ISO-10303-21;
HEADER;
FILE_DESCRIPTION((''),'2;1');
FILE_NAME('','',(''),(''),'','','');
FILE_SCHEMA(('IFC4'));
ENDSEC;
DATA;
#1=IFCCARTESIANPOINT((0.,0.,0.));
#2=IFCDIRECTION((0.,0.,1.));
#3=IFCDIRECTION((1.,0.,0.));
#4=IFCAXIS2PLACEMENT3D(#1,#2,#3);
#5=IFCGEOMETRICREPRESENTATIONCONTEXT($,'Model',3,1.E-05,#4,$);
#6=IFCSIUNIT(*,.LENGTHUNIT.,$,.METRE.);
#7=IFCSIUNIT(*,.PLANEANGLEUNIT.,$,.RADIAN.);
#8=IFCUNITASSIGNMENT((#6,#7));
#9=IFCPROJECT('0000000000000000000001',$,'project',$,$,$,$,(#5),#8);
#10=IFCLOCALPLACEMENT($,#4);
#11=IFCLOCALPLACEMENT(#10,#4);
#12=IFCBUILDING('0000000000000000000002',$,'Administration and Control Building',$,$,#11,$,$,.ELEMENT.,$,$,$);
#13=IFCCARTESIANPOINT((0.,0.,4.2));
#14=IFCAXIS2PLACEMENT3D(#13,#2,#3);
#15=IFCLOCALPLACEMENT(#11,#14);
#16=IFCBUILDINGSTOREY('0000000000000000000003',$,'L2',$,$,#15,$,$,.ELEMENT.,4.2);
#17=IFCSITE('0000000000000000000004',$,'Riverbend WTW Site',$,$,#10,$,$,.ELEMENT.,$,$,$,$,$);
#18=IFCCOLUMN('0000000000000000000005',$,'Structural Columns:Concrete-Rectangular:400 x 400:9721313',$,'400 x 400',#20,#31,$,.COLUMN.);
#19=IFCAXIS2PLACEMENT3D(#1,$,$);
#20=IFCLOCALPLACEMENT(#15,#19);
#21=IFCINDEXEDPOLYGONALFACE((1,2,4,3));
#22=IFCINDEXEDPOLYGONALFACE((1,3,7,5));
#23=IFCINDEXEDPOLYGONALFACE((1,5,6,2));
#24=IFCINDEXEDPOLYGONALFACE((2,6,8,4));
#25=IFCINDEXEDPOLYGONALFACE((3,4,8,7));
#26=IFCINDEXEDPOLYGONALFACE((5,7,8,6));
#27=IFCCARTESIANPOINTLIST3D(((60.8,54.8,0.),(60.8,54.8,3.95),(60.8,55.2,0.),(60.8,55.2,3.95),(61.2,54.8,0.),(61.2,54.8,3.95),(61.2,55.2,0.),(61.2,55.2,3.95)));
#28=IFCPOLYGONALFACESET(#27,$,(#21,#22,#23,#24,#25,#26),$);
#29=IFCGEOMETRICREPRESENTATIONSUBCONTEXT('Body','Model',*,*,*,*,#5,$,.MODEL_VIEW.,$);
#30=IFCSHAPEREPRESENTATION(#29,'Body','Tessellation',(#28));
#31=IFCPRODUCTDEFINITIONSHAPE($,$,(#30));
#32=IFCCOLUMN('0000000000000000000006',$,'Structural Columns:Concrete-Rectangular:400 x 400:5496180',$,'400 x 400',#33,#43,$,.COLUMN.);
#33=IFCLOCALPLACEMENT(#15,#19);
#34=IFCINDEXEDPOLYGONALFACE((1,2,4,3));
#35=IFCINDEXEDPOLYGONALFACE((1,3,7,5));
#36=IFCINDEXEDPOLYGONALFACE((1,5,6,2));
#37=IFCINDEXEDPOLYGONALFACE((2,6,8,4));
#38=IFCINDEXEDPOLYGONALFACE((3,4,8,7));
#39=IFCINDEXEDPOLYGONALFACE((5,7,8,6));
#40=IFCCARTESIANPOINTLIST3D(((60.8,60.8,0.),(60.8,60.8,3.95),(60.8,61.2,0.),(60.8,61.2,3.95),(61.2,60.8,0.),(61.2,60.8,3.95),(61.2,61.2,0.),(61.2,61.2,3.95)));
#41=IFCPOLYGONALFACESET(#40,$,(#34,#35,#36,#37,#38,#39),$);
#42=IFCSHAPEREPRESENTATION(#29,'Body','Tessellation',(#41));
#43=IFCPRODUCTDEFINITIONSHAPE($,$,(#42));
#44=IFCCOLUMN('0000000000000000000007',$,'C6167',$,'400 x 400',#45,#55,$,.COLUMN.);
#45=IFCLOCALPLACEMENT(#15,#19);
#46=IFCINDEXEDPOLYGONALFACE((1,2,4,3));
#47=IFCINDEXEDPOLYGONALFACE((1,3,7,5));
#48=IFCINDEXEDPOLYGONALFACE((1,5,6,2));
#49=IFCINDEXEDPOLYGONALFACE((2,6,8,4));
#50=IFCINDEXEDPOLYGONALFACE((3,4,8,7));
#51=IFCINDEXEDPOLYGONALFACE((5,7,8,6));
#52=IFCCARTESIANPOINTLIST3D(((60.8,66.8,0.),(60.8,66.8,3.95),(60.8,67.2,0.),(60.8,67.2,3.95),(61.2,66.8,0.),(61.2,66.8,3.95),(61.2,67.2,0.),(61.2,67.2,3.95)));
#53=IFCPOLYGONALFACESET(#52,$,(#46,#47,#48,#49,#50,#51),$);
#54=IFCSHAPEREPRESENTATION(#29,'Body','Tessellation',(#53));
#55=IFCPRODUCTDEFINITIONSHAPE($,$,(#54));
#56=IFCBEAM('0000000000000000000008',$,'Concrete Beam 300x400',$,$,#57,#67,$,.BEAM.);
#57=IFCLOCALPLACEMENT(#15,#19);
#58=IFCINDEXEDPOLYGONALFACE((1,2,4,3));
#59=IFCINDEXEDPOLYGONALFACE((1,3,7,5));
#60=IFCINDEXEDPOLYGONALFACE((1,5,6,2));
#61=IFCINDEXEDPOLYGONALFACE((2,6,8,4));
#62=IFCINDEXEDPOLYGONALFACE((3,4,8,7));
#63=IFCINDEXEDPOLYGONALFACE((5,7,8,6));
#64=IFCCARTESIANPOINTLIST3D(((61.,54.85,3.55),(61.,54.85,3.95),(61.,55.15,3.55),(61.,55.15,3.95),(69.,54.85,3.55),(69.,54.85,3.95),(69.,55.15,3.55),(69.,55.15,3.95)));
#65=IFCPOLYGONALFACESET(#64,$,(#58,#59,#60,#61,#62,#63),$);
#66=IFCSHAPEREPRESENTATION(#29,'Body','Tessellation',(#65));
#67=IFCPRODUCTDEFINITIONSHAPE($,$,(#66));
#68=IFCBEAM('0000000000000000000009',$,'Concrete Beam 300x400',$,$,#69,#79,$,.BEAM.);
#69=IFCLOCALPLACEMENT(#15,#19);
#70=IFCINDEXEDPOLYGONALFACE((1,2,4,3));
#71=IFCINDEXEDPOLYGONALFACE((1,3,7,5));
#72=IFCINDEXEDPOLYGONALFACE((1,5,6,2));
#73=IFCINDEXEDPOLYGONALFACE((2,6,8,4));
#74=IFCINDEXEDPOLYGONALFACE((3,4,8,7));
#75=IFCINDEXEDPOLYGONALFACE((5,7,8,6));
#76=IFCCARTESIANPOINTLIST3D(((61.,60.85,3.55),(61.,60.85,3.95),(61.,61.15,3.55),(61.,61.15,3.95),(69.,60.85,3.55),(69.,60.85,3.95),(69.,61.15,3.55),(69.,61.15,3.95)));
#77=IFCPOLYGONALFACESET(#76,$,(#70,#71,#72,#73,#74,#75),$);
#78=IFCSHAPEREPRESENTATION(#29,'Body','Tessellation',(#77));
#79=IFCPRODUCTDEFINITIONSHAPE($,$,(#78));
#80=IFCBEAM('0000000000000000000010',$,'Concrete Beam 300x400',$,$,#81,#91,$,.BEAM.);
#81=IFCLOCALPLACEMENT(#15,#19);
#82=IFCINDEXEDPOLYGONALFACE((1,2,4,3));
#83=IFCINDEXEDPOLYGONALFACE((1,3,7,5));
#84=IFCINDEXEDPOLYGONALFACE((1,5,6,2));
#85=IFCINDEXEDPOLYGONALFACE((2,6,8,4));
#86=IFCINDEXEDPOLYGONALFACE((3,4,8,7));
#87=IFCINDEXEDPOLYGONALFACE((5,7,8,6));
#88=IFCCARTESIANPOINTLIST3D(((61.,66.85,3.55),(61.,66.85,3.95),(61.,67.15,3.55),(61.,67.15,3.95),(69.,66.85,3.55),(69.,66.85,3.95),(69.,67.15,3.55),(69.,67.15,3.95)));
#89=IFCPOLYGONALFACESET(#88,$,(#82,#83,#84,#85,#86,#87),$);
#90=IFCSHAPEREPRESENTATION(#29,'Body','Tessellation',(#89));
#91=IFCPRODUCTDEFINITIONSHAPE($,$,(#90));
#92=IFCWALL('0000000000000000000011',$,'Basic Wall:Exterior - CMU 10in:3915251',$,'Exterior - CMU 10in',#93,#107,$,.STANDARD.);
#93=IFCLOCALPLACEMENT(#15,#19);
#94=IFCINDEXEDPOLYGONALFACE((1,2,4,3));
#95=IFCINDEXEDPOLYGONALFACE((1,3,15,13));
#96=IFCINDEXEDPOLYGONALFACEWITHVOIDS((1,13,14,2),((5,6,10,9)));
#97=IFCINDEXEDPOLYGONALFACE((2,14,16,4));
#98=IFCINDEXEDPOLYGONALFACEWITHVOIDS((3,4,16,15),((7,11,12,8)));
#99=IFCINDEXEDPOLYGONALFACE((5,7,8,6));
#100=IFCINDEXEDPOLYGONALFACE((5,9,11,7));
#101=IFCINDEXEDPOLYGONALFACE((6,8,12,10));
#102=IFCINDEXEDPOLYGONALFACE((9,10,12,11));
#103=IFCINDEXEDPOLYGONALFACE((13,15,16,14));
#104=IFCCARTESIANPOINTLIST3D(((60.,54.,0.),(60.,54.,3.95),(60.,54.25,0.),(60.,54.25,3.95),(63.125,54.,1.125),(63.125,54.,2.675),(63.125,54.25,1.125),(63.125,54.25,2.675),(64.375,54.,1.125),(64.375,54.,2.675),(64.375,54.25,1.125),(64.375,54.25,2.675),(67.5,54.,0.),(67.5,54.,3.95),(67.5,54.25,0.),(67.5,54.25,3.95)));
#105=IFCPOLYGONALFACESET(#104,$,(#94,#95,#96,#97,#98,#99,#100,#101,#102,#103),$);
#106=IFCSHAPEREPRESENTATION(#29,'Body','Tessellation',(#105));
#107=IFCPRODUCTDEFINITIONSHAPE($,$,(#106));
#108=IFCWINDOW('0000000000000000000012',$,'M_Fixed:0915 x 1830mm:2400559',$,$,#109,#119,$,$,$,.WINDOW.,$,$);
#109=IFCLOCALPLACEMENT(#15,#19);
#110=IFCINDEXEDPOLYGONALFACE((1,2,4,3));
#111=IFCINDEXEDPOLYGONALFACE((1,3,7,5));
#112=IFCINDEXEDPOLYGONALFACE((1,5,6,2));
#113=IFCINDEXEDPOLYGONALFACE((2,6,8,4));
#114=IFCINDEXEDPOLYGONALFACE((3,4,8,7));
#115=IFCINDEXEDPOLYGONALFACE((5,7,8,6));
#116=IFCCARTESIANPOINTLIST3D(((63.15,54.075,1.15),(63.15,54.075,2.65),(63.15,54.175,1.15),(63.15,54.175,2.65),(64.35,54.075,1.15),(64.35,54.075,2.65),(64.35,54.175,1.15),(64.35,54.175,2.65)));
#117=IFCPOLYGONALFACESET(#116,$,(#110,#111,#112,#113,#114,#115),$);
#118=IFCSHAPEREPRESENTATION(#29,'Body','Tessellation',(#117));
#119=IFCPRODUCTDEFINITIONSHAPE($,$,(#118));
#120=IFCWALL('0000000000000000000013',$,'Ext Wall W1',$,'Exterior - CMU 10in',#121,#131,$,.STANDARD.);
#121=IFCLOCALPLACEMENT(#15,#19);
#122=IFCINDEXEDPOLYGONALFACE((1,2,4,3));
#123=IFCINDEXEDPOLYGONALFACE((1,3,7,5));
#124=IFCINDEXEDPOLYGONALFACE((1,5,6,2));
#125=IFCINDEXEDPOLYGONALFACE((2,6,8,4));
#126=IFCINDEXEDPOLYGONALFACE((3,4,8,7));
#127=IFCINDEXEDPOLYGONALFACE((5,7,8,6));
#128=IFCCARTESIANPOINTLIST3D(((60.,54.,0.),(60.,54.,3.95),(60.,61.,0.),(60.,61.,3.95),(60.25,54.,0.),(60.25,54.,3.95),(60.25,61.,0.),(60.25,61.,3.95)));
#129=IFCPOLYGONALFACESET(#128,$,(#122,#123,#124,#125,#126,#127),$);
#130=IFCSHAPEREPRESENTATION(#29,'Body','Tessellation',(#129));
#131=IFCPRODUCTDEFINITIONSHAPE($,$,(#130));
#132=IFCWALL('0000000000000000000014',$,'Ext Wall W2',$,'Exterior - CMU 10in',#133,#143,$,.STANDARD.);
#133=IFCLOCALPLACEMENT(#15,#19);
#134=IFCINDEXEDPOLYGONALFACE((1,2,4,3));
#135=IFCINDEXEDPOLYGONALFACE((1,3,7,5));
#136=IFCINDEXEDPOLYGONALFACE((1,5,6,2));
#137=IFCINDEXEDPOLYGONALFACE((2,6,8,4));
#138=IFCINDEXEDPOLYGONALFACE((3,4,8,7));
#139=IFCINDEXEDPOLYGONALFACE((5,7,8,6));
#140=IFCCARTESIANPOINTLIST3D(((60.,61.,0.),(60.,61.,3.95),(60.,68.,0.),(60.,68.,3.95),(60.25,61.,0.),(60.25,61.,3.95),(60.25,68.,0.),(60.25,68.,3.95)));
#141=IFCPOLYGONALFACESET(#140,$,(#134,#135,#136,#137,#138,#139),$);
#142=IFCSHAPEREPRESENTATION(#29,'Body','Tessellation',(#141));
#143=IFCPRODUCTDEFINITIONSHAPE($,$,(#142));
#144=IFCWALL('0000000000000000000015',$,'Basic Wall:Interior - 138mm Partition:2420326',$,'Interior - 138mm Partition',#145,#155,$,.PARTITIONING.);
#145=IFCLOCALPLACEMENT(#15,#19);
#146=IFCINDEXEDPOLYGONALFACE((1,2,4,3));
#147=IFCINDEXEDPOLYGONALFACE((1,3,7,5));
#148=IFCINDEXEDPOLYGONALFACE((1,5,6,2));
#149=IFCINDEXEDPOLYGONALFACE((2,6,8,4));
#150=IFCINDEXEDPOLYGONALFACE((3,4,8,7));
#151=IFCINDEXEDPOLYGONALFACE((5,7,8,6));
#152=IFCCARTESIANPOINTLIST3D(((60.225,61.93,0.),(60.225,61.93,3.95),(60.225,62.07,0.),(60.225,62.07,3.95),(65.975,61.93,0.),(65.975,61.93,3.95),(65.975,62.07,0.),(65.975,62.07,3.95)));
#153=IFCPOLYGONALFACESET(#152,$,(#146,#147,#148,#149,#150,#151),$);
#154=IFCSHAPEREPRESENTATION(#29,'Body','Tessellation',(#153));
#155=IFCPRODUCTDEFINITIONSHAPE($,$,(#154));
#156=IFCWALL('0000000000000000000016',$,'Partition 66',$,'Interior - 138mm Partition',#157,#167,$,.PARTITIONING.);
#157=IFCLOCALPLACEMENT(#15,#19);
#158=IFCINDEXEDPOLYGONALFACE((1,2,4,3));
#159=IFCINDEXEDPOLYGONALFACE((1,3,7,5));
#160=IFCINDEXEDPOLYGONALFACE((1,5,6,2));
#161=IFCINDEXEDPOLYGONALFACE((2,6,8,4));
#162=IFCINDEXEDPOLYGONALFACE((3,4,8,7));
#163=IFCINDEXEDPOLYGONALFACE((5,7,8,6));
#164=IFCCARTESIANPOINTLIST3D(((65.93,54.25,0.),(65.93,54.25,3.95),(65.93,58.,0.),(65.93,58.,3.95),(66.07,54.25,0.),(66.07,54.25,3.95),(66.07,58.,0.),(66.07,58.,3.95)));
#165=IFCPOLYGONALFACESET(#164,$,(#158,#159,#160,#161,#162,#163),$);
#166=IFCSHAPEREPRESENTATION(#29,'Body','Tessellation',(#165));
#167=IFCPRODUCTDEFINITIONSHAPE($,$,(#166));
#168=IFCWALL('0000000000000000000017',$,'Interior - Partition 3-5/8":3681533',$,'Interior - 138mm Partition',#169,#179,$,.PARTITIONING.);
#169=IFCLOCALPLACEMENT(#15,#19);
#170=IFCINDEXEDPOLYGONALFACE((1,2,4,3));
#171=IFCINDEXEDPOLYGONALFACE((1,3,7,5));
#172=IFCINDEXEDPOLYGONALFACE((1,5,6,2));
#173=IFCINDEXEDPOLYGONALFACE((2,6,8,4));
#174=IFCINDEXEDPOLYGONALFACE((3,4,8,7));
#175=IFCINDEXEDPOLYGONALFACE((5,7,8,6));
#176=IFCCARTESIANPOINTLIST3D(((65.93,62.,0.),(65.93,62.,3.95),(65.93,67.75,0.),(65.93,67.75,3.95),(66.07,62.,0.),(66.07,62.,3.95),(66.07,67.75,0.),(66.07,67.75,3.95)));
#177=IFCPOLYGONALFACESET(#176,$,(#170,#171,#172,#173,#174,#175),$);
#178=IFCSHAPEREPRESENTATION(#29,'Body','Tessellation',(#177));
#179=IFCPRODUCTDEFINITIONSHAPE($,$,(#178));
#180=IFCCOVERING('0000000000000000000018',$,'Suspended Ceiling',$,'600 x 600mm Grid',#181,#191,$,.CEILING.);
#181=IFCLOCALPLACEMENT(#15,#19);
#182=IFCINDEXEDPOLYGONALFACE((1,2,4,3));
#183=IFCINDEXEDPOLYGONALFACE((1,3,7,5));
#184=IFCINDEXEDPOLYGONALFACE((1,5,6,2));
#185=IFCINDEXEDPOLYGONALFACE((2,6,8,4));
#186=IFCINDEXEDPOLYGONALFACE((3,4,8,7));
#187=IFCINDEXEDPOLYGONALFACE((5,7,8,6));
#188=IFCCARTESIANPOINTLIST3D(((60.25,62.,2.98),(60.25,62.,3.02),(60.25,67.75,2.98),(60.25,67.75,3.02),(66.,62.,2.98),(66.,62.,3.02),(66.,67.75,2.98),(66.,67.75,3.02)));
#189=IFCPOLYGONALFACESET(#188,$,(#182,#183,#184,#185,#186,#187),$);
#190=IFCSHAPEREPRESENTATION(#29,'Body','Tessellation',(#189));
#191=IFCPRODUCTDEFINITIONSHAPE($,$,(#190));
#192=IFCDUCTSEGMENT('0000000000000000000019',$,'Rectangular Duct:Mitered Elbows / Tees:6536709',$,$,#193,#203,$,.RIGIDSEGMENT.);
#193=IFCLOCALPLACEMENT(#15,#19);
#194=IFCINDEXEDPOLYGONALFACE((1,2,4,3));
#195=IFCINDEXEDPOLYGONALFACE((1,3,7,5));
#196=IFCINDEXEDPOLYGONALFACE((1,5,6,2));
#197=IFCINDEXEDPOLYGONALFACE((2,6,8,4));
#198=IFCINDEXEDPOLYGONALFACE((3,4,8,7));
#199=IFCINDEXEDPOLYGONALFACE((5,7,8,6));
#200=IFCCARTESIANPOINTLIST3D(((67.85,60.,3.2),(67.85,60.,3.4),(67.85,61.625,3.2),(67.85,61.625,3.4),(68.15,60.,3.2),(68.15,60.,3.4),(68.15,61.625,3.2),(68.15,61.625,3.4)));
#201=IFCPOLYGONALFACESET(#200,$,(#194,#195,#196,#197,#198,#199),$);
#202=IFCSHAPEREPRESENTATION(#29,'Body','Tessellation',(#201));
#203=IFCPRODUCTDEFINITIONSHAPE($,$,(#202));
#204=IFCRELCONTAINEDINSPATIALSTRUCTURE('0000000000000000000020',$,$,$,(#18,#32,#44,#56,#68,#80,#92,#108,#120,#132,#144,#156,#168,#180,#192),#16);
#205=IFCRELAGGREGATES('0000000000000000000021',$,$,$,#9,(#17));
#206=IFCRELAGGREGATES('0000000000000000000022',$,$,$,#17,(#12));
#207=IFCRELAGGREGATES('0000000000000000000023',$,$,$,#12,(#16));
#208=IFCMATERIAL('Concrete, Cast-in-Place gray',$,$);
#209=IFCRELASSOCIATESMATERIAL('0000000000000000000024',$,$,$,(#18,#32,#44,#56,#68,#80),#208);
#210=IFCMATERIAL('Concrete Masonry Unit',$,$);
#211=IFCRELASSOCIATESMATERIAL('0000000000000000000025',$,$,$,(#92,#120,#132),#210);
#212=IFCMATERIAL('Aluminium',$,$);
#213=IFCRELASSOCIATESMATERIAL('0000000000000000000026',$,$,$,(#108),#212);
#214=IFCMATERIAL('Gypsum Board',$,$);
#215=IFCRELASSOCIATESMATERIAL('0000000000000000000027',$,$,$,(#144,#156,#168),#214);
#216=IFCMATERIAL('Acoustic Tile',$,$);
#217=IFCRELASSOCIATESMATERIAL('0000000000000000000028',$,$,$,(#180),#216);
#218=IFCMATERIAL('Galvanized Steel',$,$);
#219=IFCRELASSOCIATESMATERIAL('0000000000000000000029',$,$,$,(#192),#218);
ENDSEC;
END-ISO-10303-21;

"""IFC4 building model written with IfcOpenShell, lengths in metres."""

from ifc_helpers import new_model, si_unit, frame, origin_with_axes, origin_2d, place, context, subcontext, project, spatial, rectangle, extrude, material, element, fill, save


model = new_model("IFC4")

# Units and contexts
model_context = context("Model", 3, precision=1e-05, world=origin_with_axes())
body_context = subcontext(model_context, "Body", "Model", "MODEL_VIEW")
ifc_project = project(units=[si_unit("LENGTHUNIT", "METRE"), si_unit("PLANEANGLEUNIT", "RADIAN")], contexts=[model_context])

# Site, building, storey
site_placement = place(None, origin_with_axes())
site = spatial("IfcSite", under=ifc_project, at=site_placement, Name="Riverbend WTW Site", CompositionType="ELEMENT")
building_placement = place(site_placement, origin_with_axes())
building = spatial("IfcBuilding", under=site, at=building_placement, Name="Administration and Control Building", CompositionType="ELEMENT")
storey_placement = place(building_placement, frame((0.0, 0.0, 4.2), z_axis=(0.0, 0.0, 1.0), x_axis=(1.0, 0.0, 0.0)))
storey = spatial("IfcBuildingStorey", under=building, at=storey_placement, Name="L2", CompositionType="ELEMENT", Elevation=4.2)

# Columns
ifc_material_1 = material(Name="Concrete, Cast-in-Place gray")
for number, where, z_axis, x_axis, name in (
    (1, (61.0, 55.0, 6.175), (0.0, 0.0, 1.0), (1.0, 0.0, 0.0), "Structural Columns:Concrete-Rectangular:400 x 400:9721313"),
    (2, (61.0, 61.0, 6.175), (0.0, 0.0, 1.0), (1.0, 0.0, 0.0), "Structural Columns:Concrete-Rectangular:400 x 400:5496180"),
    (3, (61.0, 67.0, 6.175), (0.0, 0.0, 1.0), (1.0, 0.0, 0.0), "C6167"),
):
    element("IfcColumn", number, at=place(None, frame(where, z_axis=z_axis, x_axis=x_axis)), inside=storey, material=ifc_material_1, Name=name, ObjectType="400 x 400", PredefinedType="COLUMN", context=body_context, shape_type="SweptSolid", body=[
        extrude(rectangle(XDim=0.4, YDim=0.4, at=origin_2d()), frame((0.0, 0.0, -1.975), z_axis=(0.0, 0.0, 1.0), x_axis=(1.0, 0.0, 0.0)), (0.0, 0.0, 1.0), 3.95),
    ])

# Beams
for number, where, z_axis, x_axis, name in (
    (4, (65.0, 55.0, 7.95), (0.0, 0.0, 1.0), (1.0, 0.0, 0.0), "Concrete Beam 300x400"),
    (5, (65.0, 61.0, 7.95), (0.0, 0.0, 1.0), (1.0, 0.0, 0.0), "Concrete Beam 300x400"),
    (6, (65.0, 67.0, 7.95), (0.0, 0.0, 1.0), (1.0, 0.0, 0.0), "Concrete Beam 300x400"),
):
    element("IfcBeam", number, at=place(None, frame(where, z_axis=z_axis, x_axis=x_axis)), inside=storey, material=ifc_material_1, Name=name, PredefinedType="BEAM", context=body_context, shape_type="SweptSolid", body=[
        extrude(rectangle(XDim=8.0, YDim=0.3, at=origin_2d()), frame((0.0, 0.0, -0.2), z_axis=(0.0, 0.0, 1.0), x_axis=(1.0, 0.0, 0.0)), (0.0, 0.0, 1.0), 0.4),
    ])

# Wall, opening, window
ifc_material_2 = material(Name="Concrete Masonry Unit")
wall_1_placement = place(None, frame((63.75, 54.125, 6.175), z_axis=(0.0, 0.0, 1.0), x_axis=(1.0, 0.0, 0.0)))
wall_1 = element("IfcWall", 7, at=wall_1_placement, inside=storey, material=ifc_material_2, Name="Basic Wall:Exterior - CMU 10in:3915251", ObjectType="Exterior - CMU 10in", PredefinedType="STANDARD", context=body_context, shape_type="SweptSolid", body=[
    extrude(rectangle(XDim=7.5, YDim=0.25, at=origin_2d()), frame((0.0, 0.0, -1.975), z_axis=(0.0, 0.0, 1.0), x_axis=(1.0, 0.0, 0.0)), (0.0, 0.0, 1.0), 3.95),
])
opening_placement = place(None, frame((63.75, 54.125, 6.1), z_axis=(0.0, 0.0, 1.0), x_axis=(1.0, 0.0, 0.0)))
opening = element("IfcOpeningElement", 8, at=opening_placement, inside=storey, cuts=wall_1, context=body_context, shape_type="SweptSolid", body=[
    extrude(rectangle(XDim=1.25, YDim=0.4, at=origin_2d()), frame((0.0, 0.0, -0.775), z_axis=(0.0, 0.0, 1.0), x_axis=(1.0, 0.0, 0.0)), (0.0, 0.0, 1.0), 1.55),
])
ifc_material_3 = material(Name="Aluminium")
window_placement = place(None, frame((63.75, 54.125, 6.1), z_axis=(0.0, 0.0, 1.0), x_axis=(1.0, 0.0, 0.0)))
window = element("IfcWindow", 9, at=window_placement, inside=storey, material=ifc_material_3, Name="M_Fixed:0915 x 1830mm:2400559", PredefinedType="WINDOW", context=body_context, shape_type="SweptSolid", body=[
    extrude(rectangle(XDim=1.2, YDim=0.1, at=origin_2d()), frame((0.0, 0.0, -0.75), z_axis=(0.0, 0.0, 1.0), x_axis=(1.0, 0.0, 0.0)), (0.0, 0.0, 1.0), 1.5),
])
fill(opening, window)

# Walls
for number, where, z_axis, x_axis, name in (
    (10, (60.125, 57.5, 6.175), (0.0, 0.0, 1.0), (1.0, 0.0, 0.0), "Ext Wall W1"),
    (11, (60.125, 64.5, 6.175), (0.0, 0.0, 1.0), (1.0, 0.0, 0.0), "Ext Wall W2"),
):
    element("IfcWall", number, at=place(None, frame(where, z_axis=z_axis, x_axis=x_axis)), inside=storey, material=ifc_material_2, Name=name, ObjectType="Exterior - CMU 10in", PredefinedType="STANDARD", context=body_context, shape_type="SweptSolid", body=[
        extrude(rectangle(XDim=0.25, YDim=7.0, at=origin_2d()), frame((0.0, 0.0, -1.975), z_axis=(0.0, 0.0, 1.0), x_axis=(1.0, 0.0, 0.0)), (0.0, 0.0, 1.0), 3.95),
    ])
ifc_material_4 = material(Name="Gypsum Board")
wall_2_placement = place(None, frame((63.1, 62.0, 6.175), z_axis=(0.0, 0.0, 1.0), x_axis=(1.0, 0.0, 0.0)))
element("IfcWall", 12, at=wall_2_placement, inside=storey, material=ifc_material_4, Name="Basic Wall:Interior - 138mm Partition:2420326", ObjectType="Interior - 138mm Partition", PredefinedType="PARTITIONING", context=body_context, shape_type="SweptSolid", body=[
    extrude(rectangle(XDim=5.75, YDim=0.14, at=origin_2d()), frame((0.0, 0.0, -1.975), z_axis=(0.0, 0.0, 1.0), x_axis=(1.0, 0.0, 0.0)), (0.0, 0.0, 1.0), 3.95),
])
wall_3_placement = place(None, frame((66.0, 56.125, 6.175), z_axis=(0.0, 0.0, 1.0), x_axis=(1.0, 0.0, 0.0)))
element("IfcWall", 13, at=wall_3_placement, inside=storey, material=ifc_material_4, Name="Partition 66", ObjectType="Interior - 138mm Partition", PredefinedType="PARTITIONING", context=body_context, shape_type="SweptSolid", body=[
    extrude(rectangle(XDim=0.14, YDim=3.75, at=origin_2d()), frame((0.0, 0.0, -1.975), z_axis=(0.0, 0.0, 1.0), x_axis=(1.0, 0.0, 0.0)), (0.0, 0.0, 1.0), 3.95),
])
wall_4_placement = place(None, frame((66.0, 64.875, 6.175), z_axis=(0.0, 0.0, 1.0), x_axis=(1.0, 0.0, 0.0)))
element("IfcWall", 14, at=wall_4_placement, inside=storey, material=ifc_material_4, Name="Interior - Partition 3-5/8\":3681533", ObjectType="Interior - 138mm Partition", PredefinedType="PARTITIONING", context=body_context, shape_type="SweptSolid", body=[
    extrude(rectangle(XDim=0.14, YDim=5.75, at=origin_2d()), frame((0.0, 0.0, -1.975), z_axis=(0.0, 0.0, 1.0), x_axis=(1.0, 0.0, 0.0)), (0.0, 0.0, 1.0), 3.95),
])

# Covering
ifc_material_5 = material(Name="Acoustic Tile")
covering_placement = place(None, frame((63.125, 64.875, 7.2), z_axis=(0.0, 0.0, 1.0), x_axis=(1.0, 0.0, 0.0)))
element("IfcCovering", 15, at=covering_placement, inside=storey, material=ifc_material_5, Name="Suspended Ceiling", ObjectType="600 x 600mm Grid", PredefinedType="CEILING", context=body_context, shape_type="SweptSolid", body=[
    extrude(rectangle(XDim=5.75, YDim=5.75, at=origin_2d()), frame((0.0, 0.0, -0.02), z_axis=(0.0, 0.0, 1.0), x_axis=(1.0, 0.0, 0.0)), (0.0, 0.0, 1.0), 0.04),
])

# Duct segment
ifc_material_6 = material(Name="Galvanized Steel")
duct_segment_1_placement = place(None, frame((68.0, 60.8125, 7.5), z_axis=(0.0, 0.0, 1.0), x_axis=(1.0, 0.0, 0.0)))
element("IfcDuctSegment", 16, at=duct_segment_1_placement, inside=storey, material=ifc_material_6, Name="Rectangular Duct:Mitered Elbows / Tees:6536709", PredefinedType="RIGIDSEGMENT", context=body_context, shape_type="SweptSolid", body=[
    extrude(rectangle(XDim=0.3, YDim=1.625, at=origin_2d()), frame((0.0, 0.0, -0.1), z_axis=(0.0, 0.0, 1.0), x_axis=(1.0, 0.0, 0.0)), (0.0, 0.0, 1.0), 0.2),
])

save(model, "model.ifc")
